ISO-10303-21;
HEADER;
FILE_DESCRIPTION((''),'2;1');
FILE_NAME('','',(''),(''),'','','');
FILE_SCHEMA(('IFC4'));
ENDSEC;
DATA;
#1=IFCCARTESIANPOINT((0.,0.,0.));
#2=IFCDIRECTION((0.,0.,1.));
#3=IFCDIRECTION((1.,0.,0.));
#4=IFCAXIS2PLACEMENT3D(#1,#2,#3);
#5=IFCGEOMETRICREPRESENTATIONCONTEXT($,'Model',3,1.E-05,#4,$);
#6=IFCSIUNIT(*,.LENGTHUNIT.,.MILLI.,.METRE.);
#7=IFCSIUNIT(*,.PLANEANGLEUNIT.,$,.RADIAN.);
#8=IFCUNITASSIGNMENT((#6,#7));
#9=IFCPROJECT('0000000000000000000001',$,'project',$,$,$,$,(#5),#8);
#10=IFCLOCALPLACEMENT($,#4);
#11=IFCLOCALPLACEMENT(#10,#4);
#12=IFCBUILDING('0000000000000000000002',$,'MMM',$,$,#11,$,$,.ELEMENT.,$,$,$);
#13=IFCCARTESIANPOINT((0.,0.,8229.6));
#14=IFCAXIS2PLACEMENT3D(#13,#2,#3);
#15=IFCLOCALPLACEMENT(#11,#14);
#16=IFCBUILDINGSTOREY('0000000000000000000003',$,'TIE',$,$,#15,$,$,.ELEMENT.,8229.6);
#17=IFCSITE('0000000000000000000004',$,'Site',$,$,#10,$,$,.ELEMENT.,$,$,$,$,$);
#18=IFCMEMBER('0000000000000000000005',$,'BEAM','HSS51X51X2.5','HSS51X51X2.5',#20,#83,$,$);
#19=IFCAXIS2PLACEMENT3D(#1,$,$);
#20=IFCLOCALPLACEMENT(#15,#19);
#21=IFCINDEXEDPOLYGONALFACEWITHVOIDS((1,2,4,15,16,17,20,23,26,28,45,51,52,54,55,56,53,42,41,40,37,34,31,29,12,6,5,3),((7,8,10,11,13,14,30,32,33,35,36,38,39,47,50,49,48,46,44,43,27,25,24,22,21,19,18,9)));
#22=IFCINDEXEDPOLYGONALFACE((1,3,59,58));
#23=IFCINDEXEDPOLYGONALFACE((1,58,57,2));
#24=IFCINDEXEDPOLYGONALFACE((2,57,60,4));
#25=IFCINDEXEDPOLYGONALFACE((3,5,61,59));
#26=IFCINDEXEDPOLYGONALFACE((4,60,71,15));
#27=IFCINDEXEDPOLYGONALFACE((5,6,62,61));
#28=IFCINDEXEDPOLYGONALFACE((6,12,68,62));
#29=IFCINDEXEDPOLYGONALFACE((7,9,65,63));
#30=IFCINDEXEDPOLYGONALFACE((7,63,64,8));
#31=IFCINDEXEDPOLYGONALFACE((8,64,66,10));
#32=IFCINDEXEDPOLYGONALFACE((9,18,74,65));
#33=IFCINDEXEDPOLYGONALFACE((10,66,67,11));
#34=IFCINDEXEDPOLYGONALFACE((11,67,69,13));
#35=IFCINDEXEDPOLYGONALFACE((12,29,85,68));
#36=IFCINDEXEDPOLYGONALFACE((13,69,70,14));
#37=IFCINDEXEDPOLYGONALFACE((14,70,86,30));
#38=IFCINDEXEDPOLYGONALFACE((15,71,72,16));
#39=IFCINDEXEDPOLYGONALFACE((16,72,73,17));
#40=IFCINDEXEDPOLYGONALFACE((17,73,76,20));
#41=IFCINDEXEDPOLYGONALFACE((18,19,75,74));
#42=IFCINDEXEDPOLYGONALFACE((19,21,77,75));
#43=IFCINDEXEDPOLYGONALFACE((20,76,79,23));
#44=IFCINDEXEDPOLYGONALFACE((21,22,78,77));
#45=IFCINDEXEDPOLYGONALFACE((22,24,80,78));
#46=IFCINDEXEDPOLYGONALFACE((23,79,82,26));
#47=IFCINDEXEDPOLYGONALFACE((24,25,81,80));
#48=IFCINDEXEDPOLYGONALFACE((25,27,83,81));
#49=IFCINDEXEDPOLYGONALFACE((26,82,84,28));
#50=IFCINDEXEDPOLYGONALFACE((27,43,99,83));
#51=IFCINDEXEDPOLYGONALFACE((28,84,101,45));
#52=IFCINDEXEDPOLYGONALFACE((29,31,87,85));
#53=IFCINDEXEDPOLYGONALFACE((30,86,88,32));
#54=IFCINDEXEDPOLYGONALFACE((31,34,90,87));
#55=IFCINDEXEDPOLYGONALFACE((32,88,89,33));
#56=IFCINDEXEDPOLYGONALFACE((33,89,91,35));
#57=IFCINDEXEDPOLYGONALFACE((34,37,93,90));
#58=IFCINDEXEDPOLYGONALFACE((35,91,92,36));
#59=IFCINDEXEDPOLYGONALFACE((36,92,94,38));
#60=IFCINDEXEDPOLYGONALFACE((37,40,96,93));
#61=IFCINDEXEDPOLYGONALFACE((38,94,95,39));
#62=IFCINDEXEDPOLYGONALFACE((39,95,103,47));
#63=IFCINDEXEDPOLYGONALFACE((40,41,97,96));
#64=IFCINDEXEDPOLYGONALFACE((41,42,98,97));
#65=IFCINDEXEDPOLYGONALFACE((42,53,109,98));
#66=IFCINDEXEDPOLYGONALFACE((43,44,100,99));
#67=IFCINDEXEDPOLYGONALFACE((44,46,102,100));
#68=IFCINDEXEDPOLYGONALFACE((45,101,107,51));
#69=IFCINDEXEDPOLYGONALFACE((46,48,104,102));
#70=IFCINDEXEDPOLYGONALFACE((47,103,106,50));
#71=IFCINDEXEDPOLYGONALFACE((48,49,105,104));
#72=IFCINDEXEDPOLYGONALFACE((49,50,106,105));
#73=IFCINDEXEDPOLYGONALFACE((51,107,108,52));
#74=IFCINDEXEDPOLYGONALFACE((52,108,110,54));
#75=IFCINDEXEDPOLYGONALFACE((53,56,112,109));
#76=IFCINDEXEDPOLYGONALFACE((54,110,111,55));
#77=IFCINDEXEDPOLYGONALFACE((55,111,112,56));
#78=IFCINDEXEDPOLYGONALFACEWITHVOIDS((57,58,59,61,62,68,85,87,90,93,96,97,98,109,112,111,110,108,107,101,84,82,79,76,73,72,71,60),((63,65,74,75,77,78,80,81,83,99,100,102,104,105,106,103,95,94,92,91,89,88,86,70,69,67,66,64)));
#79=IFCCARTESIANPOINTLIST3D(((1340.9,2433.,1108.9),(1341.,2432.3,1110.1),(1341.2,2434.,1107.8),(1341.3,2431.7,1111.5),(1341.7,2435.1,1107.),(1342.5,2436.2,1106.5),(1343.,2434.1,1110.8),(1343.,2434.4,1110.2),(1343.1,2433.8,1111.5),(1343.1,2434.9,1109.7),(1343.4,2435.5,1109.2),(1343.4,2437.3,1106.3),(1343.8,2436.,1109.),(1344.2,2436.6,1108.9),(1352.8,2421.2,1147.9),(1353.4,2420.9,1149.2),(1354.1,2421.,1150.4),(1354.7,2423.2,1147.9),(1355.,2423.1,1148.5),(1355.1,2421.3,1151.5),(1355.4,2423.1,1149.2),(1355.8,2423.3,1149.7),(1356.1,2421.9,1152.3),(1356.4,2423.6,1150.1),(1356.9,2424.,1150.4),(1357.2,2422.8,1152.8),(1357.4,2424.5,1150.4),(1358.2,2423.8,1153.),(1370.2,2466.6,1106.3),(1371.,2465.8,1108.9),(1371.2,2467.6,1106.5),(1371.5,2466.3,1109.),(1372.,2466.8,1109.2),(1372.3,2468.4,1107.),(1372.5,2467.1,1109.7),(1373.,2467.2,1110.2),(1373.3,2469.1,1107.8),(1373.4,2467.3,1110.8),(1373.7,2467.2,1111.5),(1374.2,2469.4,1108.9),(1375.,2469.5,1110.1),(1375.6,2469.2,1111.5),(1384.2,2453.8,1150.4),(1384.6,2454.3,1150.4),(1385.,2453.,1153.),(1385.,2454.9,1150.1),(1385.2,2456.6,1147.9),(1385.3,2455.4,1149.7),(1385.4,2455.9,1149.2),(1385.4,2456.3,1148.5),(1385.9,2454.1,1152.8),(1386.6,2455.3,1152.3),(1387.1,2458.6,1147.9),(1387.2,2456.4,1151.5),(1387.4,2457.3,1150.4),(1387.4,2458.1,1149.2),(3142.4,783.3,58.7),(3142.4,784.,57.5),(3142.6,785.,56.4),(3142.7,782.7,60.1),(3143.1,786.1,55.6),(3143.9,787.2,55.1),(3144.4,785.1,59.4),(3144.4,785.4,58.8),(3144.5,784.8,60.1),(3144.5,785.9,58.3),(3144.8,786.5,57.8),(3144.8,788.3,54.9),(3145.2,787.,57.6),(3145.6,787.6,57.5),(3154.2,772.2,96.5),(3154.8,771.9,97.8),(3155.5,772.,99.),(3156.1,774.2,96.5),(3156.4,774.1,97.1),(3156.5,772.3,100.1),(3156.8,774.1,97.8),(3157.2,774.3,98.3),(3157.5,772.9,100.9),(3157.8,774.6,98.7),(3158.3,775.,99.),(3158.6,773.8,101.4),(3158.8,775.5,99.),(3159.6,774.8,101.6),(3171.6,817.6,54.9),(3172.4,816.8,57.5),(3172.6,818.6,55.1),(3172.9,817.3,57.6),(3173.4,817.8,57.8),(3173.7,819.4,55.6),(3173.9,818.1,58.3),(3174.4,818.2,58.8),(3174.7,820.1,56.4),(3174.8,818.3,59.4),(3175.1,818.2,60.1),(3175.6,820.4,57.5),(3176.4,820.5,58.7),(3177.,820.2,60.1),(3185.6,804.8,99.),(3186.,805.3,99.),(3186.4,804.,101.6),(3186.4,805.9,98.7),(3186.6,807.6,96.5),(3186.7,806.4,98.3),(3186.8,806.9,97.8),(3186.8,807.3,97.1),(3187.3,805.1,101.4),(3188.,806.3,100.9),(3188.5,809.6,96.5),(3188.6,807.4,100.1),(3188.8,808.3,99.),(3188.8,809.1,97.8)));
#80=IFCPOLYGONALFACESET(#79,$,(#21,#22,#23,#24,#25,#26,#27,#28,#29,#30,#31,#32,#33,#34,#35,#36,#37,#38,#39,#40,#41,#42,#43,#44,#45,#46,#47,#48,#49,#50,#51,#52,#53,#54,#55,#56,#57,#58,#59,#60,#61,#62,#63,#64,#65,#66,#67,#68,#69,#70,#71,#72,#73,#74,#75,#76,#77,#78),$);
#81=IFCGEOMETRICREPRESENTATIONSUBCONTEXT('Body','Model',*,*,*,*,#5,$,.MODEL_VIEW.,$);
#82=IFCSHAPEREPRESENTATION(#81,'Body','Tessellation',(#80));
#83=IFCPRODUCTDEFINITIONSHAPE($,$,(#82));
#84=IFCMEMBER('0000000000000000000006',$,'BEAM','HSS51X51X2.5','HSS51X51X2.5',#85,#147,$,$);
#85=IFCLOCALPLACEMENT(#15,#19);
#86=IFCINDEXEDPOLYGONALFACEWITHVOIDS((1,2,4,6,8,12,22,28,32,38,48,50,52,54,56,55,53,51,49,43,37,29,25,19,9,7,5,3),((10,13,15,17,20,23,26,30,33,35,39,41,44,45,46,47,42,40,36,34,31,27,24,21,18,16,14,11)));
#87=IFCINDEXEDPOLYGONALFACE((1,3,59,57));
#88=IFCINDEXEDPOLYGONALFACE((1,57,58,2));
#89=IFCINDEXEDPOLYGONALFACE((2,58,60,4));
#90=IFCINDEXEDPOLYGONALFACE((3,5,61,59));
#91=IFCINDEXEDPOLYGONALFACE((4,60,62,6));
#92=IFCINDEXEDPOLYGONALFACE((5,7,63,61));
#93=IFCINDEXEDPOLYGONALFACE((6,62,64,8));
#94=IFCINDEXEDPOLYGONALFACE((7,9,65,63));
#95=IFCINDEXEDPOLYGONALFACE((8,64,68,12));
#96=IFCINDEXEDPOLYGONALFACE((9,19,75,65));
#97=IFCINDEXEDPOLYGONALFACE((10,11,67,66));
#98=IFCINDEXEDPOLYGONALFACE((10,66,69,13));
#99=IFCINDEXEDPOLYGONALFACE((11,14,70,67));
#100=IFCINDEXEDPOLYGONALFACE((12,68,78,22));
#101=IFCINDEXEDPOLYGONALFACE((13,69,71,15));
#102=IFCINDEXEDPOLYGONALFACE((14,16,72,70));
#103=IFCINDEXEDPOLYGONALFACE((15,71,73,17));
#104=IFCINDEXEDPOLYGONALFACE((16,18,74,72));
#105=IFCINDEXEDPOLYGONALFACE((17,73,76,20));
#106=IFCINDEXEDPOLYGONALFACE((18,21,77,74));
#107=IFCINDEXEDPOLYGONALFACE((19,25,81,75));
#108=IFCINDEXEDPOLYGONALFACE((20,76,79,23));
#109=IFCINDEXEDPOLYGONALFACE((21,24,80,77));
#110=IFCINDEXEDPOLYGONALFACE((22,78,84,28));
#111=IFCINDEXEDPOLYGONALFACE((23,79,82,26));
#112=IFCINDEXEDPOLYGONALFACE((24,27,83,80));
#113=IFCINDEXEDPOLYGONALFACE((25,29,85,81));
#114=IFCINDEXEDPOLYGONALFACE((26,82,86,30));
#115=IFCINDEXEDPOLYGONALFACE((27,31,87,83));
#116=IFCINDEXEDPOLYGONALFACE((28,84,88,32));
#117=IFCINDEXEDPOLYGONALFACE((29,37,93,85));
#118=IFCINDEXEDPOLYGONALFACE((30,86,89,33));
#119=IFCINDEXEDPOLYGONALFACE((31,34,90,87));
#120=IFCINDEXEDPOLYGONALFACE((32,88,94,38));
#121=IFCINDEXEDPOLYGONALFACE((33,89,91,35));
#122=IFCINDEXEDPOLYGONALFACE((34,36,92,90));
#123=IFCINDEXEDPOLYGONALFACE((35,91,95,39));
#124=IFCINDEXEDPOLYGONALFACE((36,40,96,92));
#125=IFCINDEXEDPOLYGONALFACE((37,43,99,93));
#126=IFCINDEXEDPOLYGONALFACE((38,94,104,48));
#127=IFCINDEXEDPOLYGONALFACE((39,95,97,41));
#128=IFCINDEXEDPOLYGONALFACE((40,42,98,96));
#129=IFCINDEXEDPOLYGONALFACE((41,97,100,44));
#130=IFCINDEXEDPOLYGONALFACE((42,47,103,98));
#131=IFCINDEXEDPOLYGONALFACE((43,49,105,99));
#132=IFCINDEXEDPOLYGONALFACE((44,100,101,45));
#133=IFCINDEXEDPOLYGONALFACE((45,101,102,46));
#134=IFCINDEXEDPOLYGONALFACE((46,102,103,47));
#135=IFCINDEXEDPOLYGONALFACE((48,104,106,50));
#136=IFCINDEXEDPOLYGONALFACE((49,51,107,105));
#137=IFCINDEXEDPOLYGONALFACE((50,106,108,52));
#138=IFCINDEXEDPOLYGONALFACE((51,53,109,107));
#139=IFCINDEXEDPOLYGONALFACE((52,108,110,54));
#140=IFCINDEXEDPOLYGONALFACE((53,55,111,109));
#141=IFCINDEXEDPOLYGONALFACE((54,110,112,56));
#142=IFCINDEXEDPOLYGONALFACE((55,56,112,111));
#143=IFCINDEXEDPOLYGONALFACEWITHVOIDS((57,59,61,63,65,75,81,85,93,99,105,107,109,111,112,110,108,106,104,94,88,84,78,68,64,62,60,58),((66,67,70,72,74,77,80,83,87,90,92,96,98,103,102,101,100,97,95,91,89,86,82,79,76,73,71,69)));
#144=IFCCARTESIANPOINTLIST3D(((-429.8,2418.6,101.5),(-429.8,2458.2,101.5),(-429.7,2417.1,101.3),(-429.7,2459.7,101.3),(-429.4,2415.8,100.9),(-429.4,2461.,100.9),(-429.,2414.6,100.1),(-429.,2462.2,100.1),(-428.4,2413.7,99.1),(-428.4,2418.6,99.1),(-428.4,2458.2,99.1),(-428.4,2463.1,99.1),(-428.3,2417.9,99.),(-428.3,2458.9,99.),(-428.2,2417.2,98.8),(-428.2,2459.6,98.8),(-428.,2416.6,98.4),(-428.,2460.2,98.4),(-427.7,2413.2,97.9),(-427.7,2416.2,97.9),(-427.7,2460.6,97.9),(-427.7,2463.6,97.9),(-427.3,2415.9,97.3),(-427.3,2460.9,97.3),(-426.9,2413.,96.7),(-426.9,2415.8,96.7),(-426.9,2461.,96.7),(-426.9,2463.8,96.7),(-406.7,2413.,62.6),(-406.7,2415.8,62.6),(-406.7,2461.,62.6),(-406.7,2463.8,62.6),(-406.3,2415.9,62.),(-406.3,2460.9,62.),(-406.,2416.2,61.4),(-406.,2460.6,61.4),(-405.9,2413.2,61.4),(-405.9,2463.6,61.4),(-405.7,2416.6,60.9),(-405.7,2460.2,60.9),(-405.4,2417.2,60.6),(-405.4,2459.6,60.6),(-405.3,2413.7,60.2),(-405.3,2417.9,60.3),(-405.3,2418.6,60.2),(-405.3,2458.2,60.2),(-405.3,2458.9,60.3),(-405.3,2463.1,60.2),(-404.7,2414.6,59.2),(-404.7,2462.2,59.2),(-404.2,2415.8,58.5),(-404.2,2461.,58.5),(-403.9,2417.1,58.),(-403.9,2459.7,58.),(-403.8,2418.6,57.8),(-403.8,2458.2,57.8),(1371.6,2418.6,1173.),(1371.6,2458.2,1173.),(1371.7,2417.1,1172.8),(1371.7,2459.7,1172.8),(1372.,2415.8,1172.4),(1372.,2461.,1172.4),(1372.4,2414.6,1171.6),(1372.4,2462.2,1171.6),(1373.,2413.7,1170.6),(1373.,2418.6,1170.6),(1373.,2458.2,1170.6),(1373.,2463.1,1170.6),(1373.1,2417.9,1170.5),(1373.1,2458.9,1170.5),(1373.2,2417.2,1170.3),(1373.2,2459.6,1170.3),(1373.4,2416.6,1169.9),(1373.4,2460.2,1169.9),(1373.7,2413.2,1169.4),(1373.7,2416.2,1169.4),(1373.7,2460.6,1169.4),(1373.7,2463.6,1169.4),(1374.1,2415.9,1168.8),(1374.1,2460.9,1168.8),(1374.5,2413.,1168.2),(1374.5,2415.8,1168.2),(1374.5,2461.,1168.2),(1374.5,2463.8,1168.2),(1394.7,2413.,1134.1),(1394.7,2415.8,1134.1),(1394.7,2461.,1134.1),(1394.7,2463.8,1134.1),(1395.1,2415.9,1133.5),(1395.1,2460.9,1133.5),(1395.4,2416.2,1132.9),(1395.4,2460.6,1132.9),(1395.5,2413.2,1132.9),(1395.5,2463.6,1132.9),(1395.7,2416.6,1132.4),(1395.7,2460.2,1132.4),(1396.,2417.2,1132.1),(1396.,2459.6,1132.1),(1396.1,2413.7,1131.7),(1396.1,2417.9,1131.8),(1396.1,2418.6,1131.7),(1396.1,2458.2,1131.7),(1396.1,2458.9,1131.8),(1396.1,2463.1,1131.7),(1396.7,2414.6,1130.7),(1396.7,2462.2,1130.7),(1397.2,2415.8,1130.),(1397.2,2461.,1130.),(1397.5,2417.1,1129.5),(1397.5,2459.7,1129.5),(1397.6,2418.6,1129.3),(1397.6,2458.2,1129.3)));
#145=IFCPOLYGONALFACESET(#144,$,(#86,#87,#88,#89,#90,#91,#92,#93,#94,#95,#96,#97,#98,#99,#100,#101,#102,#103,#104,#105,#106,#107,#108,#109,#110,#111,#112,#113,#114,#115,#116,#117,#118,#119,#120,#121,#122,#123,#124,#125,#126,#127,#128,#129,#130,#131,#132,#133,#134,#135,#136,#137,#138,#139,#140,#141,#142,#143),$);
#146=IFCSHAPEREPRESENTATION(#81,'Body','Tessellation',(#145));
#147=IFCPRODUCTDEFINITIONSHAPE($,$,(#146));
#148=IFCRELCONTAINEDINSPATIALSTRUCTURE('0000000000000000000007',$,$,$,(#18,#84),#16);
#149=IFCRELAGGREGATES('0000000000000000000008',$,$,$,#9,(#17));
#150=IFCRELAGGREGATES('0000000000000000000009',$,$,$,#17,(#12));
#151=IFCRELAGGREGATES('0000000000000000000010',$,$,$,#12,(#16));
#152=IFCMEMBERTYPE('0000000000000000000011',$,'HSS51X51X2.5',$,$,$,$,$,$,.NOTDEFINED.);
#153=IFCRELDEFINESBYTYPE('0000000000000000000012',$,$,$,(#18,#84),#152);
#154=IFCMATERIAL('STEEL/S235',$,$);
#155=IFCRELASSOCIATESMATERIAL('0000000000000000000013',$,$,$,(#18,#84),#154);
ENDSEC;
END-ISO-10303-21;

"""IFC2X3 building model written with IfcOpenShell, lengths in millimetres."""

from ifc_helpers import new_model, si_unit, frame, origin_with_axes, origin_2d_with_axis, place, context, subcontext, project, spatial, hollow_rectangle, extrude, material, type_object, element, save


model = new_model("IFC2X3")

# Units and contexts
model_context = context("Model", 3, precision=1e-05, world=origin_with_axes())
body_context = subcontext(model_context, "Body", "Model", "MODEL_VIEW")
ifc_project = project(units=[si_unit("LENGTHUNIT", "METRE", prefix="MILLI"), si_unit("PLANEANGLEUNIT", "RADIAN")], contexts=[model_context])

# Site, building, storey
site_placement = place(None, origin_with_axes())
site = spatial("IfcSite", under=ifc_project, at=site_placement, Name="Site", CompositionType="ELEMENT")
building_placement = place(site_placement, origin_with_axes())
building = spatial("IfcBuilding", under=site, at=building_placement, Name="MMM", CompositionType="ELEMENT")
storey_placement = place(building_placement, frame((0.0, 0.0, 8229.6), z_axis=(0.0, 0.0, 1.0), x_axis=(1.0, 0.0, 0.0)))
storey = spatial("IfcBuildingStorey", under=building, at=storey_placement, Name="TIE", CompositionType="ELEMENT", Elevation=8229.6)

# Shared definitions
ifc_material = material(Name="STEEL/S235")

# Members
member_type_1 = type_object("IfcMemberType", Name="HSS51X51X2.5", PredefinedType="NOTDEFINED")
member_1_placement = place(storey_placement, frame((1364.2, 2445.2, 1129.7), z_axis=(0.291676, -0.267, 0.918497), x_axis=(0.677501, -0.620184, -0.395428)))
element("IfcMember", 1, at=member_1_placement, inside=storey, type_object=member_type_1, material=ifc_material, Name="BEAM", Description="HSS51X51X2.5", ObjectType="HSS51X51X2.5", context=body_context, shape_type="SweptSolid", body=[
    extrude(hollow_rectangle(XDim=50.8, YDim=50.8, WallThickness=2.8, InnerFilletRadius=2.8, OuterFilletRadius=5.6, at=origin_2d_with_axis()), frame((2658.9, 0.0, 0.0), z_axis=(-1.0, 0.0, 0.0), x_axis=(0.0, -1.0, 0.0)), (0.0, 0.0, 1.0), 2658.9),
])
member_2_placement = place(storey_placement, frame((1384.6, 2438.4, 1151.2), z_axis=(-0.511216, 0.0, 0.859452), x_axis=(-0.859452, 0.0, -0.511216)))
element("IfcMember", 2, at=member_2_placement, inside=storey, type_object=member_type_1, material=ifc_material, Name="BEAM", Description="HSS51X51X2.5", ObjectType="HSS51X51X2.5", context=body_context, shape_type="SweptSolid", body=[
    extrude(hollow_rectangle(XDim=50.8, YDim=50.8, WallThickness=2.8, InnerFilletRadius=2.8, OuterFilletRadius=5.6, at=origin_2d_with_axis()), frame((2096.0, 0.0, 0.0), z_axis=(-1.0, 0.0, 0.0), x_axis=(0.0, -1.0, 0.0)), (0.0, 0.0, 1.0), 2096.0),
])

save(model, "model.ifc")
